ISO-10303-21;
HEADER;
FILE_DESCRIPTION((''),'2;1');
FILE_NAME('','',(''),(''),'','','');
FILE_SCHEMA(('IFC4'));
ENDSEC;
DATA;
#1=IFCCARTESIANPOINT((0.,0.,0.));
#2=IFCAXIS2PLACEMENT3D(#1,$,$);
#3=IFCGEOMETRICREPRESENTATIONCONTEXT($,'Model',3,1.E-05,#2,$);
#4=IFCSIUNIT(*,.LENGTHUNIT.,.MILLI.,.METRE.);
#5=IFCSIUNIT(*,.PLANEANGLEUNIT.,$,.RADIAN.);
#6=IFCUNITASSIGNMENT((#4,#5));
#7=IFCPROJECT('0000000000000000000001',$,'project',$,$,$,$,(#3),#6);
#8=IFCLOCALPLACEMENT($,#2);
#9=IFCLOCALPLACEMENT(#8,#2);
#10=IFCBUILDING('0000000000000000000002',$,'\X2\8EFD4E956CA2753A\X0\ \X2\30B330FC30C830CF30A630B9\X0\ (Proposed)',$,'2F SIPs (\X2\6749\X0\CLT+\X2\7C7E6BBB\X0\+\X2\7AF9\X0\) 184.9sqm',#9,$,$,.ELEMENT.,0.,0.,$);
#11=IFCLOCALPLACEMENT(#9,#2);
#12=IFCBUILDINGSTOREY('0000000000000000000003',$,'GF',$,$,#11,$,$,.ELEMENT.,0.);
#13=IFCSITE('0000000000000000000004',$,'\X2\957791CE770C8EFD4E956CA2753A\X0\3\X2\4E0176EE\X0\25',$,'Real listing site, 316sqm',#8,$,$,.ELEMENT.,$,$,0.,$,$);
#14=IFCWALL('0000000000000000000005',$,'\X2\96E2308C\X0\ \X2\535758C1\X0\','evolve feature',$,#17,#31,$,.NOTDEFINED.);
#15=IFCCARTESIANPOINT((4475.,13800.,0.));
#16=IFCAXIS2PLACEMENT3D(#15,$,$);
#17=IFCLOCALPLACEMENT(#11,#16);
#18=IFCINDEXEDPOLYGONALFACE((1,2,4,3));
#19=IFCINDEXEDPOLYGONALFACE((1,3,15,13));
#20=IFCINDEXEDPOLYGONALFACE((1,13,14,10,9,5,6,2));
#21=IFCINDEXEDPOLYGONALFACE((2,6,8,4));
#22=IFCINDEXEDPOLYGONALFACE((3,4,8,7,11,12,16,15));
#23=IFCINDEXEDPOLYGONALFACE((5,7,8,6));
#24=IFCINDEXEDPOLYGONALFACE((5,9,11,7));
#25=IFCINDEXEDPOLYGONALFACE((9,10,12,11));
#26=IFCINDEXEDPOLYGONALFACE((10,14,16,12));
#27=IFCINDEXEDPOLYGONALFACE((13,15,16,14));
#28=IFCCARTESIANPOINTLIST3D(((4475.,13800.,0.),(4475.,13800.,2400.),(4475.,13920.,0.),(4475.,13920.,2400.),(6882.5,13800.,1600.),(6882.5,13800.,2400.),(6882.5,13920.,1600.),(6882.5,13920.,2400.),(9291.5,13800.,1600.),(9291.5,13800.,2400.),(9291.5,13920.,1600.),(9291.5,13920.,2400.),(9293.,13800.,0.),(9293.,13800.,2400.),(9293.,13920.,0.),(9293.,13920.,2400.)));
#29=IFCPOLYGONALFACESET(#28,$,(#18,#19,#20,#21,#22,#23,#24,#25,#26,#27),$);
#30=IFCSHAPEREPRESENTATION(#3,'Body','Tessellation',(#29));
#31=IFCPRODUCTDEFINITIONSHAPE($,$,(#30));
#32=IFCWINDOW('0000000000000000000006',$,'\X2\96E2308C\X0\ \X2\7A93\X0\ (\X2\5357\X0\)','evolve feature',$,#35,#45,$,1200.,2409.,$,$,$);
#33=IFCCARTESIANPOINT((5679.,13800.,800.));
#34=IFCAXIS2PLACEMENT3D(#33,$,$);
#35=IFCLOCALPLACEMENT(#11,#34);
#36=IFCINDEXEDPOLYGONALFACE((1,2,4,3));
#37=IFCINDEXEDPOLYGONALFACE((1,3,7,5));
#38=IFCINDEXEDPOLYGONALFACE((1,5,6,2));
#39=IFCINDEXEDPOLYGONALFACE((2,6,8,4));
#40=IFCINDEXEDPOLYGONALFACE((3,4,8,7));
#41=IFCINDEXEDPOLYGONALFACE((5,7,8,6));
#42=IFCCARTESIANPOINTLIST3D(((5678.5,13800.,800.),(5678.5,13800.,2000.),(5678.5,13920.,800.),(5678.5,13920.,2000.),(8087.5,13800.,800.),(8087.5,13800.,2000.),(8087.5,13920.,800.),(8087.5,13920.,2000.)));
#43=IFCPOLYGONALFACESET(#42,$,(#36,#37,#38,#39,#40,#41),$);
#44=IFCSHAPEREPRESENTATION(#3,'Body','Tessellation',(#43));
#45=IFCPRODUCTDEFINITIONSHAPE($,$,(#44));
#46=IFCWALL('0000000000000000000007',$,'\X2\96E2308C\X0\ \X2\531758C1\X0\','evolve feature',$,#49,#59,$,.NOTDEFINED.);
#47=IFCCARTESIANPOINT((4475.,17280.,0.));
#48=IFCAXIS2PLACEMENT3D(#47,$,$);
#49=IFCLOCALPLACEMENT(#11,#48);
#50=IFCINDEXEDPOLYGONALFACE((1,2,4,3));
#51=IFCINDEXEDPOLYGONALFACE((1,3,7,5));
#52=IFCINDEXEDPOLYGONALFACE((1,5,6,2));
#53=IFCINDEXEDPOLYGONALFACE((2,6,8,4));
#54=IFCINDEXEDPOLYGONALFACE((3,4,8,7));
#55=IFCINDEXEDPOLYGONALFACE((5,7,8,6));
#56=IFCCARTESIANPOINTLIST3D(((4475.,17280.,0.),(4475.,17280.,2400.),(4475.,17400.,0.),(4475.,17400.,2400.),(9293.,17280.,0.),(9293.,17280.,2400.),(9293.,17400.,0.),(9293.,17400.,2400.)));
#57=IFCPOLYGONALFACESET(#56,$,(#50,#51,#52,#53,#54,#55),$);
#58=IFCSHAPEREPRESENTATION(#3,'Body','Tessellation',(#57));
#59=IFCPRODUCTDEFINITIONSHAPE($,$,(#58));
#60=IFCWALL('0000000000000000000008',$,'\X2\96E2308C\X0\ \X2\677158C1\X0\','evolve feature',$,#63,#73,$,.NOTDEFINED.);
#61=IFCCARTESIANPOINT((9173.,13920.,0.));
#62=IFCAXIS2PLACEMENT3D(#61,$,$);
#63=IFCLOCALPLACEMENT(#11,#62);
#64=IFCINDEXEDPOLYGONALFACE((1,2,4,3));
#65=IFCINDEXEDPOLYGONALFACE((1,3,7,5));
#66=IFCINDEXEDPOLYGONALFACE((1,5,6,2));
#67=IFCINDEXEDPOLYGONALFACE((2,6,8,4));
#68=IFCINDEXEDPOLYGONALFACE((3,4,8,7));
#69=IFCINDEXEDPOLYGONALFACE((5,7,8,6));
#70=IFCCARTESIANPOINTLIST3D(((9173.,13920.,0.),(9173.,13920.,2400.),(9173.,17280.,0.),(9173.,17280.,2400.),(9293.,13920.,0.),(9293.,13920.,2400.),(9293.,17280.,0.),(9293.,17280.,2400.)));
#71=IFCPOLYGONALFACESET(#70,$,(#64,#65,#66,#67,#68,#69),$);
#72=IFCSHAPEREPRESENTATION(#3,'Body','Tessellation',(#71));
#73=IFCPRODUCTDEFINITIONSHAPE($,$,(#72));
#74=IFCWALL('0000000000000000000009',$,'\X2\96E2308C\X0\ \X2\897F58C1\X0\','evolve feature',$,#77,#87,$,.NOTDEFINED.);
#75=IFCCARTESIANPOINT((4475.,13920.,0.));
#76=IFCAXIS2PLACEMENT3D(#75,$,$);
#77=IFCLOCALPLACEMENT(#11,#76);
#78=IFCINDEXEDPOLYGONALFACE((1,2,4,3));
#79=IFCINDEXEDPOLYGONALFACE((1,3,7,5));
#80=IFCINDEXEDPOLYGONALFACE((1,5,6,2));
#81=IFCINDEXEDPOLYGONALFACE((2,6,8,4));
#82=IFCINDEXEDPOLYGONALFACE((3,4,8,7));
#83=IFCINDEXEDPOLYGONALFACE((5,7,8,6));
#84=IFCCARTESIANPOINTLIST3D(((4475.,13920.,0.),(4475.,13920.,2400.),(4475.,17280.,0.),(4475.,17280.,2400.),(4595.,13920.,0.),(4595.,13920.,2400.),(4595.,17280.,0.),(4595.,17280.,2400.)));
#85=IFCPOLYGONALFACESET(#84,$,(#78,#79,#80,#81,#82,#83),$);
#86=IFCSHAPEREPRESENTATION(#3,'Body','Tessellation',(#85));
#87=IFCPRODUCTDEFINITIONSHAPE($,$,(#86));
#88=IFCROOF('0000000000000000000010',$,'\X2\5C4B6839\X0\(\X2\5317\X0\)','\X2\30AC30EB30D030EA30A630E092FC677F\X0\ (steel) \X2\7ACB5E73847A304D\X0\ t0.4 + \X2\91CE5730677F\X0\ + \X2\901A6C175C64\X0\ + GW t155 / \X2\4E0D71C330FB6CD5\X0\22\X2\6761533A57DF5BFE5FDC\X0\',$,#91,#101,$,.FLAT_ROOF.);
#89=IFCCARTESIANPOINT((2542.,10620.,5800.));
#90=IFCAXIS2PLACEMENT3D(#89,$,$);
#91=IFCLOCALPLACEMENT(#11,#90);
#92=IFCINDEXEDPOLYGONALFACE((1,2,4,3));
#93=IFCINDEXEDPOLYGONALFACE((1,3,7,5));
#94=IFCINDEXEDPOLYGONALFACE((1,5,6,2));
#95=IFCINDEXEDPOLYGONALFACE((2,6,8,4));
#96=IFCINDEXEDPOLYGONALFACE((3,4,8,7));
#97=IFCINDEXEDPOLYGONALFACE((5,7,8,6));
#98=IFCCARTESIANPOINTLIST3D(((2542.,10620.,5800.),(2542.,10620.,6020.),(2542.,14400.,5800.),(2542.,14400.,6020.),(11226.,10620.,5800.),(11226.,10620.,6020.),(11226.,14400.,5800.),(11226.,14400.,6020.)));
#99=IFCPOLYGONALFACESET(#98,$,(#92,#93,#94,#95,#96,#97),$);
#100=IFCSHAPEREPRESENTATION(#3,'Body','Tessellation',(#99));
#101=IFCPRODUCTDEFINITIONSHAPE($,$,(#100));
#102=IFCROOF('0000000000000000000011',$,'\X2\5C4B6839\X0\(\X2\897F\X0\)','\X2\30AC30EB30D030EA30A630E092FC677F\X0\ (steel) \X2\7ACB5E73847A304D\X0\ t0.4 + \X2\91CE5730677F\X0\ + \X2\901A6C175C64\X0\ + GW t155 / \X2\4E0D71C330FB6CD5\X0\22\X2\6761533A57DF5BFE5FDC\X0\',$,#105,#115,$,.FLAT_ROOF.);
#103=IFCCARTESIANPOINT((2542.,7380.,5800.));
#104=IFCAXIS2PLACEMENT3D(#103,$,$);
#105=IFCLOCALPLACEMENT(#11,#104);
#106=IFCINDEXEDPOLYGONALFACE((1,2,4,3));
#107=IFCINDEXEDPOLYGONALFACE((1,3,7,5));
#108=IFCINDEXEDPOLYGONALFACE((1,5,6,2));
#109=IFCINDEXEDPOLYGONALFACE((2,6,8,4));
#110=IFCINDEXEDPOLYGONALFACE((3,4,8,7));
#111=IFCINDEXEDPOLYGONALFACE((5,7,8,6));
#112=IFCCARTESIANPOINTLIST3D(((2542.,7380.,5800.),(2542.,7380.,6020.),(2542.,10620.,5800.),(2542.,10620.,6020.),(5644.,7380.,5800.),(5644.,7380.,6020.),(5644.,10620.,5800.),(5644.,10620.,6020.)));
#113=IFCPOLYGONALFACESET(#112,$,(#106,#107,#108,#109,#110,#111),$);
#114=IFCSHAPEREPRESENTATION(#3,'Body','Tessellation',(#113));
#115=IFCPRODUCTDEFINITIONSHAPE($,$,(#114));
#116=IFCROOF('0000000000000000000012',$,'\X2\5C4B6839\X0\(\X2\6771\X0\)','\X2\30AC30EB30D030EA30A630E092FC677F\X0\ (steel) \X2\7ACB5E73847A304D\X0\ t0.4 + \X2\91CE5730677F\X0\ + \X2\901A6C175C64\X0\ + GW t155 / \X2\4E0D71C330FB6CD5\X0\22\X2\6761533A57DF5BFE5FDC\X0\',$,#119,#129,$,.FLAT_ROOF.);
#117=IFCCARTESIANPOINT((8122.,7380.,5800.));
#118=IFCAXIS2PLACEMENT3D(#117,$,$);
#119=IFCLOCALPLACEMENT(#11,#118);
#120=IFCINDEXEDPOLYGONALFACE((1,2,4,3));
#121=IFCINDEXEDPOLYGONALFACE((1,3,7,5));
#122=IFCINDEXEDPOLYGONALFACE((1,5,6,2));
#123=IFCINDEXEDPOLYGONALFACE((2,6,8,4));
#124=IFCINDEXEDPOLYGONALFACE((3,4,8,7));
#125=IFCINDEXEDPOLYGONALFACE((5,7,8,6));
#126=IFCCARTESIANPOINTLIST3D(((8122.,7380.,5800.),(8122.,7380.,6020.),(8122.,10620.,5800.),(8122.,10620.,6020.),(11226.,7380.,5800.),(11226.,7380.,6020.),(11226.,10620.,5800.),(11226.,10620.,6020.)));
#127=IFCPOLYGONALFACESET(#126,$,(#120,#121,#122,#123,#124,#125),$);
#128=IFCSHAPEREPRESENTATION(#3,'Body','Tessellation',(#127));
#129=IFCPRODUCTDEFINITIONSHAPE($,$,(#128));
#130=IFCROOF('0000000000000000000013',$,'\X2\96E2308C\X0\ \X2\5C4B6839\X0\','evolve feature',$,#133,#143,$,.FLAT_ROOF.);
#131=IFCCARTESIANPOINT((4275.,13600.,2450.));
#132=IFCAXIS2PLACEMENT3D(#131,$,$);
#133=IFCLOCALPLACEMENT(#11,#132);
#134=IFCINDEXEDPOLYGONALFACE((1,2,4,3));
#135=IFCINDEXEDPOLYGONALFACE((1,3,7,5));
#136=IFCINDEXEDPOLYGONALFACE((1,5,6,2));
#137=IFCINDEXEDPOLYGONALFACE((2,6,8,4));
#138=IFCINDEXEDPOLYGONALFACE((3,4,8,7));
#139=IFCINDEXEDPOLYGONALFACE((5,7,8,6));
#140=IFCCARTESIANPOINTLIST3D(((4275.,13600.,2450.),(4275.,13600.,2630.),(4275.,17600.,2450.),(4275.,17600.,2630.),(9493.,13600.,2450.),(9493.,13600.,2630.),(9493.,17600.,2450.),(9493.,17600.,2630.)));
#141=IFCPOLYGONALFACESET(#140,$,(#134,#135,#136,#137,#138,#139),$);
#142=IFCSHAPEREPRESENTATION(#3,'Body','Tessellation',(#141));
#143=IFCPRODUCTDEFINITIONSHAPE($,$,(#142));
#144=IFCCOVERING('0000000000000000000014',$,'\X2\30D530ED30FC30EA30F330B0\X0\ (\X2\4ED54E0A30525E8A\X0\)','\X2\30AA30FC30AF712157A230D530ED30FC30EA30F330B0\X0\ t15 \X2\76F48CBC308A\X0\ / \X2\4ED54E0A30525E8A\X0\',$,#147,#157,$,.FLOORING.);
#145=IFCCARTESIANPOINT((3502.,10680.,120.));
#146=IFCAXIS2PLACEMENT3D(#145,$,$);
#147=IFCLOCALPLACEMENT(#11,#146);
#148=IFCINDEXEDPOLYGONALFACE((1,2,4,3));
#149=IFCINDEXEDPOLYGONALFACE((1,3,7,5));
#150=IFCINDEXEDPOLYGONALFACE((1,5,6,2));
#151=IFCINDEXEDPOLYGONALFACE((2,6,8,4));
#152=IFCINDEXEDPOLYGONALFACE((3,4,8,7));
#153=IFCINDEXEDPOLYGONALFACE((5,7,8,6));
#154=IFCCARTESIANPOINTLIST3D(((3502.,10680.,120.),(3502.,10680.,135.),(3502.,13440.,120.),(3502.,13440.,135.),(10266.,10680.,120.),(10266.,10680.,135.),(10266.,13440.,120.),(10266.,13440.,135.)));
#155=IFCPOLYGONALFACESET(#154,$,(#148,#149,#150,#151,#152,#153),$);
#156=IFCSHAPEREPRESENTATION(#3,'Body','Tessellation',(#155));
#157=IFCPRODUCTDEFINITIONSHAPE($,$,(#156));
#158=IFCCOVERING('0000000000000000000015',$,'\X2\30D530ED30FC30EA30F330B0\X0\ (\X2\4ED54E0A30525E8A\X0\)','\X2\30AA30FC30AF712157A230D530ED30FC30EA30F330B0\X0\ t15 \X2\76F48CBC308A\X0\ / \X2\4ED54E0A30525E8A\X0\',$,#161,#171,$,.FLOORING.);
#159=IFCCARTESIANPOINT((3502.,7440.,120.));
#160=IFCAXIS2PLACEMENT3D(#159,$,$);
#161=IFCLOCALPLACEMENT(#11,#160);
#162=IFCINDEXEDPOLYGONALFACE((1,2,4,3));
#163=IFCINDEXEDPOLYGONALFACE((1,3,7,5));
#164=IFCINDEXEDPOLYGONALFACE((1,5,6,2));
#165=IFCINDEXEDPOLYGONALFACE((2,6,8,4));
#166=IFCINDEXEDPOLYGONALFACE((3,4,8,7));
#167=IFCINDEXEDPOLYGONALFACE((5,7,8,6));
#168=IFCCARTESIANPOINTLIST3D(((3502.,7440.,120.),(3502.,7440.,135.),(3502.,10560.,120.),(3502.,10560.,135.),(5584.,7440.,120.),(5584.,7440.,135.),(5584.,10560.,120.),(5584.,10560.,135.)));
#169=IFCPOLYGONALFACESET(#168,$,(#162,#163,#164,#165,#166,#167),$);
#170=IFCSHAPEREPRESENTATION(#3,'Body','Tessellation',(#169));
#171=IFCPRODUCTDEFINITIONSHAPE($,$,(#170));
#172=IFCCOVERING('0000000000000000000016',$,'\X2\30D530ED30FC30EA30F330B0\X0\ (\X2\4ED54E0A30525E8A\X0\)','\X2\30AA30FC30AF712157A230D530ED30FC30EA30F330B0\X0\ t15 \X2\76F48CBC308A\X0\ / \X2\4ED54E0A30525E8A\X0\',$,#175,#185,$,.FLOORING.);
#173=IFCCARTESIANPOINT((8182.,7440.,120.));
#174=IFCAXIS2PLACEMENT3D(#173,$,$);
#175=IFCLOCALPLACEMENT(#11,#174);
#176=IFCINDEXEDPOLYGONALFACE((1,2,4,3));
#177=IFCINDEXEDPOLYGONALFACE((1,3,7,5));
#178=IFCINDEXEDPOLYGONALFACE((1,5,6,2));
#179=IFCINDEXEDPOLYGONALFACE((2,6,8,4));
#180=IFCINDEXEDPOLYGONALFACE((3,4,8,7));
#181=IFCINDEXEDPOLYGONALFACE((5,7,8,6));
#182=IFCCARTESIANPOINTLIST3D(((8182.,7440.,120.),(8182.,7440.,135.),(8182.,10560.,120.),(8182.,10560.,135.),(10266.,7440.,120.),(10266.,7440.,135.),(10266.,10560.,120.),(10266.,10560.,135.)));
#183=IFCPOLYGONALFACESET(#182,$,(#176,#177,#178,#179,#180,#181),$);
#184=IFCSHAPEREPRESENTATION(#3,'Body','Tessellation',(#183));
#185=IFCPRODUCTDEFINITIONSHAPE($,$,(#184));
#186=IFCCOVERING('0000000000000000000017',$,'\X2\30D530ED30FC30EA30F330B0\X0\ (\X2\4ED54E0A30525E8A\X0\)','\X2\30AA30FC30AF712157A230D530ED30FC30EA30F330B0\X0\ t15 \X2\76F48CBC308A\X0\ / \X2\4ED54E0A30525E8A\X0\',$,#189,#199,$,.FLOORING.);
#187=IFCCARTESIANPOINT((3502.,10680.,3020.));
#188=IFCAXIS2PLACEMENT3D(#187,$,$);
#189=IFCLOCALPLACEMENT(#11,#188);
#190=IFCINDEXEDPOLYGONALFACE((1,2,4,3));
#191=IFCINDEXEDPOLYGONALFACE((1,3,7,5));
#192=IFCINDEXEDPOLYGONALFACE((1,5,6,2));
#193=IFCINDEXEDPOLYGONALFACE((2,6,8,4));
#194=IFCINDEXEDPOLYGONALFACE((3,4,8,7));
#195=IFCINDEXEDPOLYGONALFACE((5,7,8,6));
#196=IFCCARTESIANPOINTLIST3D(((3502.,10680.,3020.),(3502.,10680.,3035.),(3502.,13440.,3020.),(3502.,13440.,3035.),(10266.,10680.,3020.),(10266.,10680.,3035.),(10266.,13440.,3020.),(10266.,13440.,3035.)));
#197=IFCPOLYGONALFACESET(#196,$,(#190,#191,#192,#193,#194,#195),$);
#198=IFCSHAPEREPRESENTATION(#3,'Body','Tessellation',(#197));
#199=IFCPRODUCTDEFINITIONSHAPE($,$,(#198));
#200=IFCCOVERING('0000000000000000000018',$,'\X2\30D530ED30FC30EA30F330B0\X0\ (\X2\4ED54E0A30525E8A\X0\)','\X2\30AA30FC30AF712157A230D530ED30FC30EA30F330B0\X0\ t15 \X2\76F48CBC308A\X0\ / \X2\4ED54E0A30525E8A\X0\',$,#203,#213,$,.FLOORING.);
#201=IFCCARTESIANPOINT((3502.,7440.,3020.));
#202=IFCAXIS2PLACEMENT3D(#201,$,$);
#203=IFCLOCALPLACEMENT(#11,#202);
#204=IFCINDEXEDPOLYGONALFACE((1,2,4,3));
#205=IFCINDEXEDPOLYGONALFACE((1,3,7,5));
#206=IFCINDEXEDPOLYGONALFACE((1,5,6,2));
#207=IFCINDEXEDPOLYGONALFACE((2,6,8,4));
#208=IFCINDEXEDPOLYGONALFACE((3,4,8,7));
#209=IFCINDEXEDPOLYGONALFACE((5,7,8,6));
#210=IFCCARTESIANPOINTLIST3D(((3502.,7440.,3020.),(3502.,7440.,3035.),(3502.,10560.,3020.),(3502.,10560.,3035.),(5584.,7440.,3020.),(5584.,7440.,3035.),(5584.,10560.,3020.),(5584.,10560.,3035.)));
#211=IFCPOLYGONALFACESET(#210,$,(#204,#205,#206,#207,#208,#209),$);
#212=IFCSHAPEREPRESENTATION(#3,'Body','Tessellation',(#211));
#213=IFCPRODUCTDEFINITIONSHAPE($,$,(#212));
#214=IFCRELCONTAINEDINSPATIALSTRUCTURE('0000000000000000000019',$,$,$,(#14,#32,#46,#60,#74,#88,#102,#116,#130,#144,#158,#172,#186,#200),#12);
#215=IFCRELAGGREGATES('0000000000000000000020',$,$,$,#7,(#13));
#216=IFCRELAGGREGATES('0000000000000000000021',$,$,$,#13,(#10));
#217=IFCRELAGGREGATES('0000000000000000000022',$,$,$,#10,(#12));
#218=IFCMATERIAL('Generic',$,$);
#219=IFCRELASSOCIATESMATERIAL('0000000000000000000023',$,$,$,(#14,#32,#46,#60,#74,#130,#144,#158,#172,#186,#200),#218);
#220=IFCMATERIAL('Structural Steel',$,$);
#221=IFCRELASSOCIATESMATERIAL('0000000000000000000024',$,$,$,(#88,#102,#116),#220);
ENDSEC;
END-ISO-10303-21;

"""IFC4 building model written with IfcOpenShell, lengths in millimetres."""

from ifc_helpers import new_model, si_unit, frame, frame_2d, origin, place, context, project, spatial, rectangle, extrude, material, element, fill, save


model = new_model("IFC4")

# Units and contexts
model_context = context("Model", 3, precision=1e-05, world=origin())
ifc_project = project(units=[si_unit("LENGTHUNIT", "METRE", prefix="MILLI"), si_unit("PLANEANGLEUNIT", "RADIAN")], contexts=[model_context])

# Site, building, storey
site_placement = place(None, origin())
site = spatial("IfcSite", under=ifc_project, at=site_placement, Name="長野県軽井沢町3丁目25", ObjectType="Real listing site, 316sqm", CompositionType="ELEMENT", RefElevation=0.0)
building_placement = place(site_placement, origin())
building = spatial("IfcBuilding", under=site, at=building_placement, Name="軽井沢町 コートハウス (Proposed)", ObjectType="2F SIPs (杉CLT+籾殻+竹) 184.9sqm", CompositionType="ELEMENT", ElevationOfRefHeight=0.0, ElevationOfTerrain=0.0)
storey_placement = place(building_placement, origin())
storey = spatial("IfcBuildingStorey", under=building, at=storey_placement, Name="GF", CompositionType="ELEMENT", Elevation=0.0)

# Shared definitions
ifc_material_1 = material(Name="Generic")

# Wall, opening, window
wall_1_placement = place(storey_placement, frame((4475.0, 13800.0, 0.0)))
wall_1 = element("IfcWall", 1, at=wall_1_placement, inside=storey, material=ifc_material_1, Name="離れ 南壁", Description="evolve feature", PredefinedType="NOTDEFINED", context=model_context, shape_type="SweptSolid", body=[
    extrude(rectangle(XDim=4818.0, YDim=120.0, at=frame_2d((2409.0, 60.0))), frame((4475.0, 13800.0, 0.0)), (0.0, 0.0, 1.0), 2400.0),
])
opening_1_placement = place(storey_placement, frame((5679.0, 13800.0, 800.0)))
opening_1 = element("IfcOpeningElement", 2, at=opening_1_placement, cuts=wall_1, PredefinedType="NOTDEFINED", context=model_context, shape_type="SweptSolid", body=[
    extrude(rectangle(XDim=2409.0, YDim=120.0, at=frame_2d((1204.0, 60.0))), frame((5679.0, 13800.0, 800.0)), (0.0, 0.0, 1.0), 1200.0),
])
window_1_placement = place(storey_placement, frame((5679.0, 13800.0, 800.0)))
window_1 = element("IfcWindow", 3, at=window_1_placement, inside=storey, material=ifc_material_1, Name="離れ 窓 (南)", Description="evolve feature", OverallHeight=1200.0, OverallWidth=2409.0, context=model_context, shape_type="SweptSolid", body=[
    extrude(rectangle(XDim=2409.0, YDim=120.0, at=frame_2d((1204.0, 60.0))), frame((5679.0, 13800.0, 800.0)), (0.0, 0.0, 1.0), 1200.0),
])
fill(opening_1, window_1)

# Walls
wall_2_placement = place(storey_placement, frame((4475.0, 17280.0, 0.0)))
element("IfcWall", 4, at=wall_2_placement, inside=storey, material=ifc_material_1, Name="離れ 北壁", Description="evolve feature", PredefinedType="NOTDEFINED", context=model_context, shape_type="SweptSolid", body=[
    extrude(rectangle(XDim=4818.0, YDim=120.0, at=frame_2d((2409.0, 60.0))), frame((4475.0, 17280.0, 0.0)), (0.0, 0.0, 1.0), 2400.0),
])
wall_3_placement = place(storey_placement, frame((9173.0, 13920.0, 0.0)))
element("IfcWall", 5, at=wall_3_placement, inside=storey, material=ifc_material_1, Name="離れ 東壁", Description="evolve feature", PredefinedType="NOTDEFINED", context=model_context, shape_type="SweptSolid", body=[
    extrude(rectangle(XDim=120.0, YDim=3360.0, at=frame_2d((60.0, 1680.0))), frame((9173.0, 13920.0, 0.0)), (0.0, 0.0, 1.0), 2400.0),
])
wall_4_placement = place(storey_placement, frame((4475.0, 13920.0, 0.0)))
element("IfcWall", 6, at=wall_4_placement, inside=storey, material=ifc_material_1, Name="離れ 西壁", Description="evolve feature", PredefinedType="NOTDEFINED", context=model_context, shape_type="SweptSolid", body=[
    extrude(rectangle(XDim=120.0, YDim=3360.0, at=frame_2d((60.0, 1680.0))), frame((4475.0, 13920.0, 0.0)), (0.0, 0.0, 1.0), 2400.0),
])

# Roofs
ifc_material_2 = material(Name="Structural Steel")
for number, where, name in (
    (7, (2542.0, 10620.0, 5800.0), "屋根(北)"),
):
    element("IfcRoof", number, at=place(storey_placement, frame(where)), inside=storey, material=ifc_material_2, Name=name, Description="ガルバリウム鋼板 (steel) 立平葺き t0.4 + 野地板 + 通気層 + GW t155 / 不燃・法22条区域対応", PredefinedType="FLAT_ROOF", context=model_context, shape_type="SweptSolid", body=[
        extrude(rectangle(XDim=8684.0, YDim=3780.0, at=frame_2d((4342.0, 1890.0))), frame((2542.0, 10620.0, 5800.0)), (0.0, 0.0, 1.0), 220.0),
    ])
roof_1_placement = place(storey_placement, frame((2542.0, 7380.0, 5800.0)))
element("IfcRoof", 8, at=roof_1_placement, inside=storey, material=ifc_material_2, Name="屋根(西)", Description="ガルバリウム鋼板 (steel) 立平葺き t0.4 + 野地板 + 通気層 + GW t155 / 不燃・法22条区域対応", PredefinedType="FLAT_ROOF", context=model_context, shape_type="SweptSolid", body=[
    extrude(rectangle(XDim=3102.0, YDim=3240.0, at=frame_2d((1551.0, 1620.0))), frame((2542.0, 7380.0, 5800.0)), (0.0, 0.0, 1.0), 220.0),
])
roof_2_placement = place(storey_placement, frame((8122.0, 7380.0, 5800.0)))
element("IfcRoof", 9, at=roof_2_placement, inside=storey, material=ifc_material_2, Name="屋根(東)", Description="ガルバリウム鋼板 (steel) 立平葺き t0.4 + 野地板 + 通気層 + GW t155 / 不燃・法22条区域対応", PredefinedType="FLAT_ROOF", context=model_context, shape_type="SweptSolid", body=[
    extrude(rectangle(XDim=3104.0, YDim=3240.0, at=frame_2d((1552.0, 1620.0))), frame((8122.0, 7380.0, 5800.0)), (0.0, 0.0, 1.0), 220.0),
])
roof_3_placement = place(storey_placement, frame((4275.0, 13600.0, 2450.0)))
element("IfcRoof", 10, at=roof_3_placement, inside=storey, material=ifc_material_1, Name="離れ 屋根", Description="evolve feature", PredefinedType="FLAT_ROOF", context=model_context, shape_type="SweptSolid", body=[
    extrude(rectangle(XDim=5218.0, YDim=4000.0, at=frame_2d((2609.0, 2000.0))), frame((4275.0, 13600.0, 2450.0)), (0.0, 0.0, 1.0), 180.0),
])

# Coverings
covering_1_placement = place(storey_placement, frame((3502.0, 10680.0, 120.0)))
element("IfcCovering", 11, at=covering_1_placement, inside=storey, material=ifc_material_1, Name="フローリング (仕上げ床)", Description="オーク無垢フローリング t15 直貼り / 仕上げ床", PredefinedType="FLOORING", context=model_context, shape_type="SweptSolid", body=[
    extrude(rectangle(XDim=6764.0, YDim=2760.0, at=frame_2d((3382.0, 1380.0))), frame((3502.0, 10680.0, 120.0)), (0.0, 0.0, 1.0), 15.0),
])
covering_2_placement = place(storey_placement, frame((3502.0, 7440.0, 120.0)))
element("IfcCovering", 12, at=covering_2_placement, inside=storey, material=ifc_material_1, Name="フローリング (仕上げ床)", Description="オーク無垢フローリング t15 直貼り / 仕上げ床", PredefinedType="FLOORING", context=model_context, shape_type="SweptSolid", body=[
    extrude(rectangle(XDim=2082.0, YDim=3120.0, at=frame_2d((1041.0, 1560.0))), frame((3502.0, 7440.0, 120.0)), (0.0, 0.0, 1.0), 15.0),
])
covering_3_placement = place(storey_placement, frame((8182.0, 7440.0, 120.0)))
element("IfcCovering", 13, at=covering_3_placement, inside=storey, material=ifc_material_1, Name="フローリング (仕上げ床)", Description="オーク無垢フローリング t15 直貼り / 仕上げ床", PredefinedType="FLOORING", context=model_context, shape_type="SweptSolid", body=[
    extrude(rectangle(XDim=2084.0, YDim=3120.0, at=frame_2d((1042.0, 1560.0))), frame((8182.0, 7440.0, 120.0)), (0.0, 0.0, 1.0), 15.0),
])
covering_4_placement = place(storey_placement, frame((3502.0, 10680.0, 3020.0)))
element("IfcCovering", 14, at=covering_4_placement, inside=storey, material=ifc_material_1, Name="フローリング (仕上げ床)", Description="オーク無垢フローリング t15 直貼り / 仕上げ床", PredefinedType="FLOORING", context=model_context, shape_type="SweptSolid", body=[
    extrude(rectangle(XDim=6764.0, YDim=2760.0, at=frame_2d((3382.0, 1380.0))), frame((3502.0, 10680.0, 3020.0)), (0.0, 0.0, 1.0), 15.0),
])
covering_5_placement = place(storey_placement, frame((3502.0, 7440.0, 3020.0)))
element("IfcCovering", 15, at=covering_5_placement, inside=storey, material=ifc_material_1, Name="フローリング (仕上げ床)", Description="オーク無垢フローリング t15 直貼り / 仕上げ床", PredefinedType="FLOORING", context=model_context, shape_type="SweptSolid", body=[
    extrude(rectangle(XDim=2082.0, YDim=3120.0, at=frame_2d((1041.0, 1560.0))), frame((3502.0, 7440.0, 3020.0)), (0.0, 0.0, 1.0), 15.0),
])

save(model, "model.ifc")
